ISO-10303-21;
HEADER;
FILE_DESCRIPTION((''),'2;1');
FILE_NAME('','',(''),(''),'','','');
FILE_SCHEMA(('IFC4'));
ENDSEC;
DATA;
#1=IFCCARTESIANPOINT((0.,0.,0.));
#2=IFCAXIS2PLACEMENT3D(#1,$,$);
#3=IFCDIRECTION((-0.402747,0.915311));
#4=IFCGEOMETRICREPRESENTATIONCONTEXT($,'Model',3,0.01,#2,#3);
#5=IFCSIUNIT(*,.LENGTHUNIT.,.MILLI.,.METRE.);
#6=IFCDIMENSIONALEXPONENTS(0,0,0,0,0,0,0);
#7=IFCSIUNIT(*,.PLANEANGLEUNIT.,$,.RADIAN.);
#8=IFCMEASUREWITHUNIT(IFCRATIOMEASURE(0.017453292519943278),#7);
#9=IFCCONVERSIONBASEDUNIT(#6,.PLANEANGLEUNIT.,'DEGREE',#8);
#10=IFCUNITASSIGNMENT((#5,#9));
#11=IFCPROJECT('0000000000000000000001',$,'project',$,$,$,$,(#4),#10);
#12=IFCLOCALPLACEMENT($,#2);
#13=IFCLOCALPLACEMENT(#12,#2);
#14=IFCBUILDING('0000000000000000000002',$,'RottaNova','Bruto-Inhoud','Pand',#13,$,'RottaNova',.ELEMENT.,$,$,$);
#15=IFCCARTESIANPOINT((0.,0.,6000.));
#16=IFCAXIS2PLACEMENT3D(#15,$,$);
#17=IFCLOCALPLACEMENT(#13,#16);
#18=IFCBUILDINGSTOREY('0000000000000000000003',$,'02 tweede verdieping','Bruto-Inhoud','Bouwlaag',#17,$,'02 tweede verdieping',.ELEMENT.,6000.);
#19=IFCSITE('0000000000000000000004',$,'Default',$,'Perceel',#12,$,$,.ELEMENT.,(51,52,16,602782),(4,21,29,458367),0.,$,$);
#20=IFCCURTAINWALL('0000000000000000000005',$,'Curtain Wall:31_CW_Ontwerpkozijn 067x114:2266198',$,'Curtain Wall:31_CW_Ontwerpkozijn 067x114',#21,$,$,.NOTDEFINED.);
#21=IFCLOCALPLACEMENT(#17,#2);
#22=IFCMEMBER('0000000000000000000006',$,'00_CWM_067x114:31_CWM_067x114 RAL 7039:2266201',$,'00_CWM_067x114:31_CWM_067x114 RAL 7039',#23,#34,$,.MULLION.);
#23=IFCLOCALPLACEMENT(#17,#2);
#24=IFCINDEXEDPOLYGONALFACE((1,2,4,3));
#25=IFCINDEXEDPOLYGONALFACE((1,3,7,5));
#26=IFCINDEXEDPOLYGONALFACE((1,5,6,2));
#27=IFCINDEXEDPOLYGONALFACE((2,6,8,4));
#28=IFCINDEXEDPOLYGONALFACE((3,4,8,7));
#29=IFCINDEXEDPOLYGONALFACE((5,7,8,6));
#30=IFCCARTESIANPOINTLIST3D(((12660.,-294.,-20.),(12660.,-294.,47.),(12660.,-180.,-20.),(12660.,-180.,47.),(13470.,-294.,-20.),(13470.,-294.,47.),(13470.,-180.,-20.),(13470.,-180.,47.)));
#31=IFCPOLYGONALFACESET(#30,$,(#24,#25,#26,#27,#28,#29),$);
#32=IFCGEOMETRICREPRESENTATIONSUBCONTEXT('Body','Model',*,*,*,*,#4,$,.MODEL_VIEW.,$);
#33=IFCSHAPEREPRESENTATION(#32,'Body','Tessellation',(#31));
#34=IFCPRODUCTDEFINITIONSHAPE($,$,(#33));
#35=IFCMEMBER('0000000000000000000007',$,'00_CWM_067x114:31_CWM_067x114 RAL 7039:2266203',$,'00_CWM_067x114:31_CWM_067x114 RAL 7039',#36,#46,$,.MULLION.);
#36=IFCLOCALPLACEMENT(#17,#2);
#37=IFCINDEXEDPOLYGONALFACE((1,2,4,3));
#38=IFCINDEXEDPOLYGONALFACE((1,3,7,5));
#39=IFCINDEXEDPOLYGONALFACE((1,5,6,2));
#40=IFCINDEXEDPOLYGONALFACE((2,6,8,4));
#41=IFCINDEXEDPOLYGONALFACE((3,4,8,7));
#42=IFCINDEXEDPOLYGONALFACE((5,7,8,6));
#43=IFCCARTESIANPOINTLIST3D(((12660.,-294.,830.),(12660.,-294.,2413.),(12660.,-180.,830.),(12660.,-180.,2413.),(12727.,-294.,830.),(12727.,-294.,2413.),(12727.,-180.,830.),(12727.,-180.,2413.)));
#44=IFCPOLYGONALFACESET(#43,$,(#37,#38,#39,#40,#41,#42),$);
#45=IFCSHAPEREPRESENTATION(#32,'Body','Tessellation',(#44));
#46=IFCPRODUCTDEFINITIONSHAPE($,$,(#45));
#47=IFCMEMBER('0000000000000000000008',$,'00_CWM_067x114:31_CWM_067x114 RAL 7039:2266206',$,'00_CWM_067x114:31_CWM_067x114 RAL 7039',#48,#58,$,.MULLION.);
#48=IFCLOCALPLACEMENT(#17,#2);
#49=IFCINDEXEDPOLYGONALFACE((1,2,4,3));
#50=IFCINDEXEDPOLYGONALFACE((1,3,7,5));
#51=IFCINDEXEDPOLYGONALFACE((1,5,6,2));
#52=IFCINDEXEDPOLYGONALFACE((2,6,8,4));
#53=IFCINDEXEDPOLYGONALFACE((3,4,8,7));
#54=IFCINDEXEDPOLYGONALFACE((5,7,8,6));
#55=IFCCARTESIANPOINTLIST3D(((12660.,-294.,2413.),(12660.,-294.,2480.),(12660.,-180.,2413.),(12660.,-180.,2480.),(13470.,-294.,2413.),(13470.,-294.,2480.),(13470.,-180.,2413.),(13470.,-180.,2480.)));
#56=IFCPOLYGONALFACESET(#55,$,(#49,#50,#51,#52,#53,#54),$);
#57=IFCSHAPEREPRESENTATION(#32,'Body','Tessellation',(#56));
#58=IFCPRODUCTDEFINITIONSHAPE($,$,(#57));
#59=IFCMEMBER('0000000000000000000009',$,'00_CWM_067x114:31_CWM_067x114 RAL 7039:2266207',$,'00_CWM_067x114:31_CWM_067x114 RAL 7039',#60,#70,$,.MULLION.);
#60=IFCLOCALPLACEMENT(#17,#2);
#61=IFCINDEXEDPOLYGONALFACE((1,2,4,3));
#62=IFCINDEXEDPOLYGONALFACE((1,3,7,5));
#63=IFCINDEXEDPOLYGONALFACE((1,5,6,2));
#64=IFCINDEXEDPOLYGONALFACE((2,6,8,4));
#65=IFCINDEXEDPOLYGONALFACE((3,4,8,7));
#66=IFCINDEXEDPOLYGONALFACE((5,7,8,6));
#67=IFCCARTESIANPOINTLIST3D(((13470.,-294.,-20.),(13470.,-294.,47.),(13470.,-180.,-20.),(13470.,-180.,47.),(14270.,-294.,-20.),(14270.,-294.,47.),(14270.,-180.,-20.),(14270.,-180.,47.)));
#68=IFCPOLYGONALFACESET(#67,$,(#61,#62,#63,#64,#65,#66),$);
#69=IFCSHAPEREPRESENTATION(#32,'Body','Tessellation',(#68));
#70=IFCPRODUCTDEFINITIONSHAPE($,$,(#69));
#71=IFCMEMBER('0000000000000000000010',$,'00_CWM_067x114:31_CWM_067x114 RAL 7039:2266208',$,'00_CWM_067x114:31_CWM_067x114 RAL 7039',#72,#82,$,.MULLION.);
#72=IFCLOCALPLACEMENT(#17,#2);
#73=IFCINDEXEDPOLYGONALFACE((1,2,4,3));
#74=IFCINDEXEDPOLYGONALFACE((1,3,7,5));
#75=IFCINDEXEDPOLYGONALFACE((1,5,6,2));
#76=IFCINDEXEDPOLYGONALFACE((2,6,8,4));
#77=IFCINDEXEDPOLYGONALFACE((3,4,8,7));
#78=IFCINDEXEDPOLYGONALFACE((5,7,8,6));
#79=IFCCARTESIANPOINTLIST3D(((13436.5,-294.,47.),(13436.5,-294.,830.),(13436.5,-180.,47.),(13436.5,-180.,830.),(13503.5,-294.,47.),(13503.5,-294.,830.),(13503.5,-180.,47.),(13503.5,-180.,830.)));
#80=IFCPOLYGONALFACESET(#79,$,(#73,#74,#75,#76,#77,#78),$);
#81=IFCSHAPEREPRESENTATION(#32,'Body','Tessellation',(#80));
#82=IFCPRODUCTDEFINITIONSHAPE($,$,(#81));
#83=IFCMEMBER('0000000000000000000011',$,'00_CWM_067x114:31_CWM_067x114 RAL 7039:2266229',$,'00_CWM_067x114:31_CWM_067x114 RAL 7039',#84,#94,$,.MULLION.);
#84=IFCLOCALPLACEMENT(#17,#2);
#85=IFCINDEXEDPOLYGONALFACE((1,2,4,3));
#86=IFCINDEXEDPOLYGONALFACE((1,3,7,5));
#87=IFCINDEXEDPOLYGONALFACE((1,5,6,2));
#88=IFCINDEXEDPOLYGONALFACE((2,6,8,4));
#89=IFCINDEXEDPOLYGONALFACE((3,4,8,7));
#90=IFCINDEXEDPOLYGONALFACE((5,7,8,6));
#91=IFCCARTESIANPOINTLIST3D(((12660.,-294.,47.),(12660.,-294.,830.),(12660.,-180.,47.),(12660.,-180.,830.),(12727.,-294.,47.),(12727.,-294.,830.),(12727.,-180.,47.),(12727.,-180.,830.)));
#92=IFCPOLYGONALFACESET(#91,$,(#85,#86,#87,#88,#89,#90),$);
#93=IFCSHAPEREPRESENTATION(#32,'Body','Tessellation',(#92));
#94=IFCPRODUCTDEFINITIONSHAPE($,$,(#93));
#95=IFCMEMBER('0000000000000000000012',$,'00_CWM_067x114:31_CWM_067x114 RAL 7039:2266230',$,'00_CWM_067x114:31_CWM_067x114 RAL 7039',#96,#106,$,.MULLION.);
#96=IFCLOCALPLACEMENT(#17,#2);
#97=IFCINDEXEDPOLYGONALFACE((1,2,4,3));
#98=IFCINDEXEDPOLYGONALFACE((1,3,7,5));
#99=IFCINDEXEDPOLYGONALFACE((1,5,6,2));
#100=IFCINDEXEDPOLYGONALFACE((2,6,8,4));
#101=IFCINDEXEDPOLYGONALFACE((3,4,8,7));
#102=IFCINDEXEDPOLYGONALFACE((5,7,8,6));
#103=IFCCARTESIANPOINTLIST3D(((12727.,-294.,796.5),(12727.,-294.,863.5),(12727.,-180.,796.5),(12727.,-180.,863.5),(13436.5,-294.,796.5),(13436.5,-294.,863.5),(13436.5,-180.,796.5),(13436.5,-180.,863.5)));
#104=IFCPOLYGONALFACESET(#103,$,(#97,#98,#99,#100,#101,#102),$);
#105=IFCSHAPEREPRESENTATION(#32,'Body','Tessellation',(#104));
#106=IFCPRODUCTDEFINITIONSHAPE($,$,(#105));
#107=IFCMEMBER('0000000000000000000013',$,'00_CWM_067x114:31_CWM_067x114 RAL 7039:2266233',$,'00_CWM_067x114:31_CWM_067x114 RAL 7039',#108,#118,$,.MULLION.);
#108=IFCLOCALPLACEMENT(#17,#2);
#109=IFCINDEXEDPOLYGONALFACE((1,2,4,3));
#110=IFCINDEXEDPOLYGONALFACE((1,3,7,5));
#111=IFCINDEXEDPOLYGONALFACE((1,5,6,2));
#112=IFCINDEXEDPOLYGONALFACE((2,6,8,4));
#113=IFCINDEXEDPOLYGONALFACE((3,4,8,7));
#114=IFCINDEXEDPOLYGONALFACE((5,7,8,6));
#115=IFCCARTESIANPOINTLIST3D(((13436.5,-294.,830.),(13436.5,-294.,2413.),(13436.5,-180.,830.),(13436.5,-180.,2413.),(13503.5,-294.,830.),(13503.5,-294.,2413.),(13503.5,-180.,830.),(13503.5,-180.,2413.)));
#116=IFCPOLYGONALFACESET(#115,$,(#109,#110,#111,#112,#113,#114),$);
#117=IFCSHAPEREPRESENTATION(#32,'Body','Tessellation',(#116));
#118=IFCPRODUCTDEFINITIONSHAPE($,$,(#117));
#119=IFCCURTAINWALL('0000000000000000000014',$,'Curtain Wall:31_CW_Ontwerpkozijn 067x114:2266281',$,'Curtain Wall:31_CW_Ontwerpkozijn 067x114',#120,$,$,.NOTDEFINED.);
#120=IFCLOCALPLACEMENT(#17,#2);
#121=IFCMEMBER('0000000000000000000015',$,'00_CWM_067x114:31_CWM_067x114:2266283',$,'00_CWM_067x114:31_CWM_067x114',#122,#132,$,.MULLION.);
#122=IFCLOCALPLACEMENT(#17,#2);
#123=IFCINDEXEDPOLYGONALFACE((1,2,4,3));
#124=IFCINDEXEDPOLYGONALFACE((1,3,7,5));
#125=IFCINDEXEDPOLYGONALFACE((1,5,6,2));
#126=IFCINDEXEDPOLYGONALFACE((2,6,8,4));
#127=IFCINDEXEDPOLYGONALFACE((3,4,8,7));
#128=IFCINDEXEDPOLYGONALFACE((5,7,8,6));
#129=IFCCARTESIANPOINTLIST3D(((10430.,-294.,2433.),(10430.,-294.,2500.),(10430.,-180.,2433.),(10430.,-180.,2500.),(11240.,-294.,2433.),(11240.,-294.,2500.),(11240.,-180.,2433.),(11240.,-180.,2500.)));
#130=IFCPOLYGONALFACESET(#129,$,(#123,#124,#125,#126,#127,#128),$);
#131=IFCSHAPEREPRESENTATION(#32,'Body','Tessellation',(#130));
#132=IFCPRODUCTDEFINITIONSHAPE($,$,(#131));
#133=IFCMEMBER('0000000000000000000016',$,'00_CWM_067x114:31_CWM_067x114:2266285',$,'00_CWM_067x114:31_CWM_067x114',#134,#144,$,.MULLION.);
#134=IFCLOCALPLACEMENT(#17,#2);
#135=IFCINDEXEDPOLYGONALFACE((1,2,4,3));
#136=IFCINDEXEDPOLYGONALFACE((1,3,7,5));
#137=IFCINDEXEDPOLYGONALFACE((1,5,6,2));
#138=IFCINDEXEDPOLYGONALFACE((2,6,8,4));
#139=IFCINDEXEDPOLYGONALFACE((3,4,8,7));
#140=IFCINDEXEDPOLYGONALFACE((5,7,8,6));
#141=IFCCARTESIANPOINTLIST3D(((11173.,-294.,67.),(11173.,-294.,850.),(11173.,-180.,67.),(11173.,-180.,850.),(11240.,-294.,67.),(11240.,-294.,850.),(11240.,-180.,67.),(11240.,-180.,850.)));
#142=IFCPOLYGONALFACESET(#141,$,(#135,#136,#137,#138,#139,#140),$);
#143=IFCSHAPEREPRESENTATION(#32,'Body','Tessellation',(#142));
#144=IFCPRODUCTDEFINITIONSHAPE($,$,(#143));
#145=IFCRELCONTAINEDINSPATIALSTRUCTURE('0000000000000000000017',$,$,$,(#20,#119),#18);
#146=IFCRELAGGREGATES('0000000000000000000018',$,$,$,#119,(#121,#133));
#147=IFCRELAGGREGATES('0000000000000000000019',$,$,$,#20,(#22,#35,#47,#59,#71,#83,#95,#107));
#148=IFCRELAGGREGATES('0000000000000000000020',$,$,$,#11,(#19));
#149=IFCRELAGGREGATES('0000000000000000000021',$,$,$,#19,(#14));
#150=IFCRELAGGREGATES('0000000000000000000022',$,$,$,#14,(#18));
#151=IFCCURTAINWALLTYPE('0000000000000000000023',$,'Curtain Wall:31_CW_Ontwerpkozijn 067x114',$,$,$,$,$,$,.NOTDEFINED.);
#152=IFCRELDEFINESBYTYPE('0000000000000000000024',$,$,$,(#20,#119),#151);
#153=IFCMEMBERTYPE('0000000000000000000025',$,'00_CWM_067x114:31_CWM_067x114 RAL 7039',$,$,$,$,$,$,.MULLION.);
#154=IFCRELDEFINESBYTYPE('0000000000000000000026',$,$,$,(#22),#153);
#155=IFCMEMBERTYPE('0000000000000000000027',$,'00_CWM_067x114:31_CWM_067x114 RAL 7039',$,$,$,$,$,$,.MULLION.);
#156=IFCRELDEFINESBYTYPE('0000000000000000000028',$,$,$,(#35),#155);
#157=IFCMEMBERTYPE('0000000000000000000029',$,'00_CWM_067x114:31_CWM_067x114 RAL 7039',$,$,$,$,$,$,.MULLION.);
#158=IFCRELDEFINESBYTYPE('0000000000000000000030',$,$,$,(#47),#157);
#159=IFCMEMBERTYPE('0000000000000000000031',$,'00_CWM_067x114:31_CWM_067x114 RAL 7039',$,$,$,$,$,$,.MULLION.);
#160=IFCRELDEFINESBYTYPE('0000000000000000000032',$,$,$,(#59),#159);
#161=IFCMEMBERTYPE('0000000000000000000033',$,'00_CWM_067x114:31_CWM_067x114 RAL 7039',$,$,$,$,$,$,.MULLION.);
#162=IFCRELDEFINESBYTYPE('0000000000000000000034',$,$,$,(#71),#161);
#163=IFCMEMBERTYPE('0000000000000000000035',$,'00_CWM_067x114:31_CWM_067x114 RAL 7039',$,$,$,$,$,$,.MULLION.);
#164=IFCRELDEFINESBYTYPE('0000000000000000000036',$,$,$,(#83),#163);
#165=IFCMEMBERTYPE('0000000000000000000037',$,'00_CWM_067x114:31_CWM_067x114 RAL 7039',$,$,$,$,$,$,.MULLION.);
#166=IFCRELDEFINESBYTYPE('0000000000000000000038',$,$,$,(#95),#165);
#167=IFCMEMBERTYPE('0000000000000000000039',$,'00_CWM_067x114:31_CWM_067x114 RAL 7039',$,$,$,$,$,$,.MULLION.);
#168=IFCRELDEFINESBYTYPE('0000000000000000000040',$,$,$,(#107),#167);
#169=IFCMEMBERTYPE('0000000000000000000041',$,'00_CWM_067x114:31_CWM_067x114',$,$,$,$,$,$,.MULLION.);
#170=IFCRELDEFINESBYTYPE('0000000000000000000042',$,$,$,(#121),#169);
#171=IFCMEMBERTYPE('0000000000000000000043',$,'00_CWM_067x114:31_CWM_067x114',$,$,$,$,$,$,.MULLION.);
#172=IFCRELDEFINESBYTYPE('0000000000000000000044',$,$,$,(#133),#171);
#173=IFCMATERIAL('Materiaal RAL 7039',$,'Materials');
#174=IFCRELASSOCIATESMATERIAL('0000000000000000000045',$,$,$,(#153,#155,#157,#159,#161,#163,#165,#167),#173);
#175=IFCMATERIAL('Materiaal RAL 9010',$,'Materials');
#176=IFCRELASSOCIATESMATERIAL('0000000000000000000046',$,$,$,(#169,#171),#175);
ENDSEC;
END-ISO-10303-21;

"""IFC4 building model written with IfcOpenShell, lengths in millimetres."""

from ifc_helpers import new_model, entity, si_unit, converted_unit, direction, frame, origin, origin_2d_with_axis, place, context, subcontext, project, spatial, rectangle, extrude, source, transform, mapped, material, material_profile, profile_set, type_object, type_shapes, element, aggregate, save


model = new_model("IFC4")

# Units and contexts
model_context = context("Model", 3, precision=0.01, world=origin(), true_north=direction((-0.402747, 0.915311)))
body_context = subcontext(model_context, "Body", "Model", "MODEL_VIEW")
ifc_project = project(units=[si_unit("LENGTHUNIT", "METRE", prefix="MILLI"), converted_unit("PLANEANGLEUNIT", "DEGREE", entity("IfcRatioMeasure", 0.017453292519943278), si_unit("PLANEANGLEUNIT", "RADIAN"), dimensions=[0, 0, 0, 0, 0, 0, 0])], contexts=[model_context])

# Site, building, storey
site_placement = place(None, origin())
site = spatial("IfcSite", under=ifc_project, at=site_placement, Name="Default", ObjectType="Perceel", CompositionType="ELEMENT", RefLatitude=(51, 52, 16, 602782), RefLongitude=(4, 21, 29, 458367), RefElevation=0.0)
building_placement = place(site_placement, origin())
building = spatial("IfcBuilding", under=site, at=building_placement, Name="RottaNova", Description="Bruto-Inhoud", ObjectType="Pand", LongName="RottaNova", CompositionType="ELEMENT")
storey_placement = place(building_placement, frame((0.0, 0.0, 6000.0)))
storey = spatial("IfcBuildingStorey", under=building, at=storey_placement, Name="02 tweede verdieping", Description="Bruto-Inhoud", ObjectType="Bouwlaag", LongName="02 tweede verdieping", CompositionType="ELEMENT", Elevation=6000.0)

# Curtain walls, members
curtain_wall_type = type_object("IfcCurtainWallType", Name="Curtain Wall:31_CW_Ontwerpkozijn 067x114", PredefinedType="NOTDEFINED")
curtain_wall_1_placement = place(storey_placement, frame((0.0, 0.0, -6000.0)))
curtain_wall_1 = element("IfcCurtainWall", 1, at=curtain_wall_1_placement, inside=storey, type_object=curtain_wall_type, Name="Curtain Wall:31_CW_Ontwerpkozijn 067x114:2266198", ObjectType="Curtain Wall:31_CW_Ontwerpkozijn 067x114", PredefinedType="NOTDEFINED")
ifc_material_1 = material(Name="Materiaal RAL 7039", Category="Materials")
ifc_material_profile_1 = material_profile(ifc_material_1, rectangle(XDim=114.0, YDim=67.0, at=origin_2d_with_axis()), Name="31_CWM_067x114 RAL 7039")
ifc_profile_set_1 = profile_set([ifc_material_profile_1], Name="31_CWM_067x114 RAL 7039")
member_type_1 = type_object("IfcMemberType", Name="00_CWM_067x114:31_CWM_067x114 RAL 7039", PredefinedType="MULLION", material=ifc_profile_set_1)
shared_shape_1 = source(origin(), body_context, "Body", "SweptSolid", [
    extrude(rectangle(XDim=114.0, YDim=67.0, at=origin_2d_with_axis()), frame((-33.5, 57.0, -810.0), z_axis=(0.0, 0.0, 1.0), x_axis=(0.0, -1.0, 0.0)), (0.0, 0.0, 1.0), 810.0),
])
type_shapes(member_type_1, [shared_shape_1])
member_1_placement = place(curtain_wall_1_placement, frame((12660.0, -180.0, 5980.0), z_axis=(-1.0, 0.0, 0.0), x_axis=(0.0, 0.0, -1.0)))
member_1 = element("IfcMember", 2, at=member_1_placement, type_object=member_type_1, Name="00_CWM_067x114:31_CWM_067x114 RAL 7039:2266201", ObjectType="00_CWM_067x114:31_CWM_067x114 RAL 7039", PredefinedType="MULLION", context=body_context, shape_type="MappedRepresentation", body=[
    mapped(shared_shape_1, transform((0.0, 0.0, 0.0), scale=1.0)),
])
member_type_2 = type_object("IfcMemberType", Name="00_CWM_067x114:31_CWM_067x114 RAL 7039", PredefinedType="MULLION", material=ifc_profile_set_1)
shared_shape_2 = source(origin(), body_context, "Body", "SweptSolid", [
    extrude(rectangle(XDim=114.0, YDim=67.0, at=origin_2d_with_axis()), frame((-33.5, 57.0, -1583.0), z_axis=(0.0, 0.0, 1.0), x_axis=(0.0, -1.0, 0.0)), (0.0, 0.0, 1.0), 1583.0),
])
type_shapes(member_type_2, [shared_shape_2])
member_2_placement = place(curtain_wall_1_placement, frame((12660.0, -180.0, 8413.0), z_axis=(0.0, 0.0, 1.0), x_axis=(-1.0, 0.0, 0.0)))
member_2 = element("IfcMember", 3, at=member_2_placement, type_object=member_type_2, Name="00_CWM_067x114:31_CWM_067x114 RAL 7039:2266203", ObjectType="00_CWM_067x114:31_CWM_067x114 RAL 7039", PredefinedType="MULLION", context=body_context, shape_type="MappedRepresentation", body=[
    mapped(shared_shape_2, transform((0.0, 0.0, 0.0), scale=1.0)),
])
member_type_3 = type_object("IfcMemberType", Name="00_CWM_067x114:31_CWM_067x114 RAL 7039", PredefinedType="MULLION", material=ifc_profile_set_1)
shared_shape_3 = source(origin(), body_context, "Body", "SweptSolid", [
    extrude(rectangle(XDim=114.0, YDim=67.0, at=origin_2d_with_axis()), frame((-33.5, 57.0, -810.0), z_axis=(0.0, 0.0, 1.0), x_axis=(0.0, -1.0, 0.0)), (0.0, 0.0, 1.0), 810.0),
])
type_shapes(member_type_3, [shared_shape_3])
member_3_placement = place(curtain_wall_1_placement, frame((13470.0, -180.0, 8480.0), z_axis=(1.0, 0.0, 0.0), x_axis=(0.0, 0.0, 1.0)))
member_3 = element("IfcMember", 4, at=member_3_placement, type_object=member_type_3, Name="00_CWM_067x114:31_CWM_067x114 RAL 7039:2266206", ObjectType="00_CWM_067x114:31_CWM_067x114 RAL 7039", PredefinedType="MULLION", context=body_context, shape_type="MappedRepresentation", body=[
    mapped(shared_shape_3, transform((0.0, 0.0, 0.0), scale=1.0)),
])
member_type_4 = type_object("IfcMemberType", Name="00_CWM_067x114:31_CWM_067x114 RAL 7039", PredefinedType="MULLION", material=ifc_profile_set_1)
shared_shape_4 = source(origin(), body_context, "Body", "SweptSolid", [
    extrude(rectangle(XDim=114.0, YDim=67.0, at=origin_2d_with_axis()), frame((-33.5, 57.0, -800.0), z_axis=(0.0, 0.0, 1.0), x_axis=(0.0, -1.0, 0.0)), (0.0, 0.0, 1.0), 800.0),
])
type_shapes(member_type_4, [shared_shape_4])
member_4_placement = place(curtain_wall_1_placement, frame((13470.0, -180.0, 5980.0), z_axis=(-1.0, 0.0, 0.0), x_axis=(0.0, 0.0, -1.0)))
member_4 = element("IfcMember", 5, at=member_4_placement, type_object=member_type_4, Name="00_CWM_067x114:31_CWM_067x114 RAL 7039:2266207", ObjectType="00_CWM_067x114:31_CWM_067x114 RAL 7039", PredefinedType="MULLION", context=body_context, shape_type="MappedRepresentation", body=[
    mapped(shared_shape_4, transform((0.0, 0.0, 0.0), scale=1.0)),
])
member_type_5 = type_object("IfcMemberType", Name="00_CWM_067x114:31_CWM_067x114 RAL 7039", PredefinedType="MULLION", material=ifc_profile_set_1)
shared_shape_5 = source(origin(), body_context, "Body", "SweptSolid", [
    extrude(rectangle(XDim=114.0, YDim=67.0, at=origin_2d_with_axis()), frame((0.0, 57.0, -783.0), z_axis=(0.0, 0.0, 1.0), x_axis=(0.0, -1.0, 0.0)), (0.0, 0.0, 1.0), 783.0),
])
type_shapes(member_type_5, [shared_shape_5])
member_5_placement = place(curtain_wall_1_placement, frame((13470.0, -180.0, 6047.0), z_axis=(0.0, 0.0, -1.0), x_axis=(1.0, 0.0, 0.0)))
member_5 = element("IfcMember", 6, at=member_5_placement, type_object=member_type_5, Name="00_CWM_067x114:31_CWM_067x114 RAL 7039:2266208", ObjectType="00_CWM_067x114:31_CWM_067x114 RAL 7039", PredefinedType="MULLION", context=body_context, shape_type="MappedRepresentation", body=[
    mapped(shared_shape_5, transform((0.0, 0.0, 0.0), scale=1.0)),
])
member_type_6 = type_object("IfcMemberType", Name="00_CWM_067x114:31_CWM_067x114 RAL 7039", PredefinedType="MULLION", material=ifc_profile_set_1)
shared_shape_6 = source(origin(), body_context, "Body", "SweptSolid", [
    extrude(rectangle(XDim=114.0, YDim=67.0, at=origin_2d_with_axis()), frame((-33.5, 57.0, -783.0), z_axis=(0.0, 0.0, 1.0), x_axis=(0.0, -1.0, 0.0)), (0.0, 0.0, 1.0), 783.0),
])
type_shapes(member_type_6, [shared_shape_6])
member_6_placement = place(curtain_wall_1_placement, frame((12660.0, -180.0, 6830.0), z_axis=(0.0, 0.0, 1.0), x_axis=(-1.0, 0.0, 0.0)))
member_6 = element("IfcMember", 7, at=member_6_placement, type_object=member_type_6, Name="00_CWM_067x114:31_CWM_067x114 RAL 7039:2266229", ObjectType="00_CWM_067x114:31_CWM_067x114 RAL 7039", PredefinedType="MULLION", context=body_context, shape_type="MappedRepresentation", body=[
    mapped(shared_shape_6, transform((0.0, 0.0, 0.0), scale=1.0)),
])
member_type_7 = type_object("IfcMemberType", Name="00_CWM_067x114:31_CWM_067x114 RAL 7039", PredefinedType="MULLION", material=ifc_profile_set_1)
shared_shape_7 = source(origin(), body_context, "Body", "SweptSolid", [
    extrude(rectangle(XDim=114.0, YDim=67.0, at=origin_2d_with_axis()), frame((0.0, 57.0, -709.5), z_axis=(0.0, 0.0, 1.0), x_axis=(0.0, -1.0, 0.0)), (0.0, 0.0, 1.0), 709.5),
])
type_shapes(member_type_7, [shared_shape_7])
member_7_placement = place(curtain_wall_1_placement, frame((13436.5, -180.0, 6830.0), z_axis=(1.0, 0.0, 0.0), x_axis=(0.0, 0.0, 1.0)))
member_7 = element("IfcMember", 8, at=member_7_placement, type_object=member_type_7, Name="00_CWM_067x114:31_CWM_067x114 RAL 7039:2266230", ObjectType="00_CWM_067x114:31_CWM_067x114 RAL 7039", PredefinedType="MULLION", context=body_context, shape_type="MappedRepresentation", body=[
    mapped(shared_shape_7, transform((0.0, 0.0, 0.0), scale=1.0)),
])
member_type_8 = type_object("IfcMemberType", Name="00_CWM_067x114:31_CWM_067x114 RAL 7039", PredefinedType="MULLION", material=ifc_profile_set_1)
shared_shape_8 = source(origin(), body_context, "Body", "SweptSolid", [
    extrude(rectangle(XDim=114.0, YDim=67.0, at=origin_2d_with_axis()), frame((0.0, 57.0, -1583.0), z_axis=(0.0, 0.0, 1.0), x_axis=(0.0, -1.0, 0.0)), (0.0, 0.0, 1.0), 1583.0),
])
type_shapes(member_type_8, [shared_shape_8])
member_8_placement = place(curtain_wall_1_placement, frame((13470.0, -180.0, 6830.0), z_axis=(0.0, 0.0, -1.0), x_axis=(1.0, 0.0, 0.0)))
member_8 = element("IfcMember", 9, at=member_8_placement, type_object=member_type_8, Name="00_CWM_067x114:31_CWM_067x114 RAL 7039:2266233", ObjectType="00_CWM_067x114:31_CWM_067x114 RAL 7039", PredefinedType="MULLION", context=body_context, shape_type="MappedRepresentation", body=[
    mapped(shared_shape_8, transform((0.0, 0.0, 0.0), scale=1.0)),
])
curtain_wall_2_placement = place(storey_placement, frame((0.0, 0.0, -6000.0)))
curtain_wall_2 = element("IfcCurtainWall", 10, at=curtain_wall_2_placement, inside=storey, type_object=curtain_wall_type, Name="Curtain Wall:31_CW_Ontwerpkozijn 067x114:2266281", ObjectType="Curtain Wall:31_CW_Ontwerpkozijn 067x114", PredefinedType="NOTDEFINED")
ifc_material_2 = material(Name="Materiaal RAL 9010", Category="Materials")
ifc_material_profile_2 = material_profile(ifc_material_2, rectangle(XDim=114.0, YDim=67.0, at=origin_2d_with_axis()), Name="31_CWM_067x114")
ifc_profile_set_2 = profile_set([ifc_material_profile_2], Name="31_CWM_067x114")
member_type_9 = type_object("IfcMemberType", Name="00_CWM_067x114:31_CWM_067x114", PredefinedType="MULLION", material=ifc_profile_set_2)
shared_shape_9 = source(origin(), body_context, "Body", "SweptSolid", [
    extrude(rectangle(XDim=114.0, YDim=67.0, at=origin_2d_with_axis()), frame((-33.5, 57.0, -810.0), z_axis=(0.0, 0.0, 1.0), x_axis=(0.0, -1.0, 0.0)), (0.0, 0.0, 1.0), 810.0),
])
type_shapes(member_type_9, [shared_shape_9])
member_9_placement = place(curtain_wall_2_placement, frame((11240.0, -180.0, 8500.0), z_axis=(1.0, 0.0, 0.0), x_axis=(0.0, 0.0, 1.0)))
member_9 = element("IfcMember", 11, at=member_9_placement, type_object=member_type_9, Name="00_CWM_067x114:31_CWM_067x114:2266283", ObjectType="00_CWM_067x114:31_CWM_067x114", PredefinedType="MULLION", context=body_context, shape_type="MappedRepresentation", body=[
    mapped(shared_shape_9, transform((0.0, 0.0, 0.0), scale=1.0)),
])
member_type_10 = type_object("IfcMemberType", Name="00_CWM_067x114:31_CWM_067x114", PredefinedType="MULLION", material=ifc_profile_set_2)
shared_shape_10 = source(origin(), body_context, "Body", "SweptSolid", [
    extrude(rectangle(XDim=114.0, YDim=67.0, at=origin_2d_with_axis()), frame((-33.5, 57.0, -783.0), z_axis=(0.0, 0.0, 1.0), x_axis=(0.0, -1.0, 0.0)), (0.0, 0.0, 1.0), 783.0),
])
type_shapes(member_type_10, [shared_shape_10])
member_10_placement = place(curtain_wall_2_placement, frame((11240.0, -180.0, 6067.0), z_axis=(0.0, 0.0, -1.0), x_axis=(1.0, 0.0, 0.0)))
member_10 = element("IfcMember", 12, at=member_10_placement, type_object=member_type_10, Name="00_CWM_067x114:31_CWM_067x114:2266285", ObjectType="00_CWM_067x114:31_CWM_067x114", PredefinedType="MULLION", context=body_context, shape_type="MappedRepresentation", body=[
    mapped(shared_shape_10, transform((0.0, 0.0, 0.0), scale=1.0)),
])
aggregate(curtain_wall_2, [member_9, member_10])

aggregate(curtain_wall_1, [member_1, member_2, member_3, member_4, member_5, member_6, member_7, member_8])

save(model, "model.ifc")
